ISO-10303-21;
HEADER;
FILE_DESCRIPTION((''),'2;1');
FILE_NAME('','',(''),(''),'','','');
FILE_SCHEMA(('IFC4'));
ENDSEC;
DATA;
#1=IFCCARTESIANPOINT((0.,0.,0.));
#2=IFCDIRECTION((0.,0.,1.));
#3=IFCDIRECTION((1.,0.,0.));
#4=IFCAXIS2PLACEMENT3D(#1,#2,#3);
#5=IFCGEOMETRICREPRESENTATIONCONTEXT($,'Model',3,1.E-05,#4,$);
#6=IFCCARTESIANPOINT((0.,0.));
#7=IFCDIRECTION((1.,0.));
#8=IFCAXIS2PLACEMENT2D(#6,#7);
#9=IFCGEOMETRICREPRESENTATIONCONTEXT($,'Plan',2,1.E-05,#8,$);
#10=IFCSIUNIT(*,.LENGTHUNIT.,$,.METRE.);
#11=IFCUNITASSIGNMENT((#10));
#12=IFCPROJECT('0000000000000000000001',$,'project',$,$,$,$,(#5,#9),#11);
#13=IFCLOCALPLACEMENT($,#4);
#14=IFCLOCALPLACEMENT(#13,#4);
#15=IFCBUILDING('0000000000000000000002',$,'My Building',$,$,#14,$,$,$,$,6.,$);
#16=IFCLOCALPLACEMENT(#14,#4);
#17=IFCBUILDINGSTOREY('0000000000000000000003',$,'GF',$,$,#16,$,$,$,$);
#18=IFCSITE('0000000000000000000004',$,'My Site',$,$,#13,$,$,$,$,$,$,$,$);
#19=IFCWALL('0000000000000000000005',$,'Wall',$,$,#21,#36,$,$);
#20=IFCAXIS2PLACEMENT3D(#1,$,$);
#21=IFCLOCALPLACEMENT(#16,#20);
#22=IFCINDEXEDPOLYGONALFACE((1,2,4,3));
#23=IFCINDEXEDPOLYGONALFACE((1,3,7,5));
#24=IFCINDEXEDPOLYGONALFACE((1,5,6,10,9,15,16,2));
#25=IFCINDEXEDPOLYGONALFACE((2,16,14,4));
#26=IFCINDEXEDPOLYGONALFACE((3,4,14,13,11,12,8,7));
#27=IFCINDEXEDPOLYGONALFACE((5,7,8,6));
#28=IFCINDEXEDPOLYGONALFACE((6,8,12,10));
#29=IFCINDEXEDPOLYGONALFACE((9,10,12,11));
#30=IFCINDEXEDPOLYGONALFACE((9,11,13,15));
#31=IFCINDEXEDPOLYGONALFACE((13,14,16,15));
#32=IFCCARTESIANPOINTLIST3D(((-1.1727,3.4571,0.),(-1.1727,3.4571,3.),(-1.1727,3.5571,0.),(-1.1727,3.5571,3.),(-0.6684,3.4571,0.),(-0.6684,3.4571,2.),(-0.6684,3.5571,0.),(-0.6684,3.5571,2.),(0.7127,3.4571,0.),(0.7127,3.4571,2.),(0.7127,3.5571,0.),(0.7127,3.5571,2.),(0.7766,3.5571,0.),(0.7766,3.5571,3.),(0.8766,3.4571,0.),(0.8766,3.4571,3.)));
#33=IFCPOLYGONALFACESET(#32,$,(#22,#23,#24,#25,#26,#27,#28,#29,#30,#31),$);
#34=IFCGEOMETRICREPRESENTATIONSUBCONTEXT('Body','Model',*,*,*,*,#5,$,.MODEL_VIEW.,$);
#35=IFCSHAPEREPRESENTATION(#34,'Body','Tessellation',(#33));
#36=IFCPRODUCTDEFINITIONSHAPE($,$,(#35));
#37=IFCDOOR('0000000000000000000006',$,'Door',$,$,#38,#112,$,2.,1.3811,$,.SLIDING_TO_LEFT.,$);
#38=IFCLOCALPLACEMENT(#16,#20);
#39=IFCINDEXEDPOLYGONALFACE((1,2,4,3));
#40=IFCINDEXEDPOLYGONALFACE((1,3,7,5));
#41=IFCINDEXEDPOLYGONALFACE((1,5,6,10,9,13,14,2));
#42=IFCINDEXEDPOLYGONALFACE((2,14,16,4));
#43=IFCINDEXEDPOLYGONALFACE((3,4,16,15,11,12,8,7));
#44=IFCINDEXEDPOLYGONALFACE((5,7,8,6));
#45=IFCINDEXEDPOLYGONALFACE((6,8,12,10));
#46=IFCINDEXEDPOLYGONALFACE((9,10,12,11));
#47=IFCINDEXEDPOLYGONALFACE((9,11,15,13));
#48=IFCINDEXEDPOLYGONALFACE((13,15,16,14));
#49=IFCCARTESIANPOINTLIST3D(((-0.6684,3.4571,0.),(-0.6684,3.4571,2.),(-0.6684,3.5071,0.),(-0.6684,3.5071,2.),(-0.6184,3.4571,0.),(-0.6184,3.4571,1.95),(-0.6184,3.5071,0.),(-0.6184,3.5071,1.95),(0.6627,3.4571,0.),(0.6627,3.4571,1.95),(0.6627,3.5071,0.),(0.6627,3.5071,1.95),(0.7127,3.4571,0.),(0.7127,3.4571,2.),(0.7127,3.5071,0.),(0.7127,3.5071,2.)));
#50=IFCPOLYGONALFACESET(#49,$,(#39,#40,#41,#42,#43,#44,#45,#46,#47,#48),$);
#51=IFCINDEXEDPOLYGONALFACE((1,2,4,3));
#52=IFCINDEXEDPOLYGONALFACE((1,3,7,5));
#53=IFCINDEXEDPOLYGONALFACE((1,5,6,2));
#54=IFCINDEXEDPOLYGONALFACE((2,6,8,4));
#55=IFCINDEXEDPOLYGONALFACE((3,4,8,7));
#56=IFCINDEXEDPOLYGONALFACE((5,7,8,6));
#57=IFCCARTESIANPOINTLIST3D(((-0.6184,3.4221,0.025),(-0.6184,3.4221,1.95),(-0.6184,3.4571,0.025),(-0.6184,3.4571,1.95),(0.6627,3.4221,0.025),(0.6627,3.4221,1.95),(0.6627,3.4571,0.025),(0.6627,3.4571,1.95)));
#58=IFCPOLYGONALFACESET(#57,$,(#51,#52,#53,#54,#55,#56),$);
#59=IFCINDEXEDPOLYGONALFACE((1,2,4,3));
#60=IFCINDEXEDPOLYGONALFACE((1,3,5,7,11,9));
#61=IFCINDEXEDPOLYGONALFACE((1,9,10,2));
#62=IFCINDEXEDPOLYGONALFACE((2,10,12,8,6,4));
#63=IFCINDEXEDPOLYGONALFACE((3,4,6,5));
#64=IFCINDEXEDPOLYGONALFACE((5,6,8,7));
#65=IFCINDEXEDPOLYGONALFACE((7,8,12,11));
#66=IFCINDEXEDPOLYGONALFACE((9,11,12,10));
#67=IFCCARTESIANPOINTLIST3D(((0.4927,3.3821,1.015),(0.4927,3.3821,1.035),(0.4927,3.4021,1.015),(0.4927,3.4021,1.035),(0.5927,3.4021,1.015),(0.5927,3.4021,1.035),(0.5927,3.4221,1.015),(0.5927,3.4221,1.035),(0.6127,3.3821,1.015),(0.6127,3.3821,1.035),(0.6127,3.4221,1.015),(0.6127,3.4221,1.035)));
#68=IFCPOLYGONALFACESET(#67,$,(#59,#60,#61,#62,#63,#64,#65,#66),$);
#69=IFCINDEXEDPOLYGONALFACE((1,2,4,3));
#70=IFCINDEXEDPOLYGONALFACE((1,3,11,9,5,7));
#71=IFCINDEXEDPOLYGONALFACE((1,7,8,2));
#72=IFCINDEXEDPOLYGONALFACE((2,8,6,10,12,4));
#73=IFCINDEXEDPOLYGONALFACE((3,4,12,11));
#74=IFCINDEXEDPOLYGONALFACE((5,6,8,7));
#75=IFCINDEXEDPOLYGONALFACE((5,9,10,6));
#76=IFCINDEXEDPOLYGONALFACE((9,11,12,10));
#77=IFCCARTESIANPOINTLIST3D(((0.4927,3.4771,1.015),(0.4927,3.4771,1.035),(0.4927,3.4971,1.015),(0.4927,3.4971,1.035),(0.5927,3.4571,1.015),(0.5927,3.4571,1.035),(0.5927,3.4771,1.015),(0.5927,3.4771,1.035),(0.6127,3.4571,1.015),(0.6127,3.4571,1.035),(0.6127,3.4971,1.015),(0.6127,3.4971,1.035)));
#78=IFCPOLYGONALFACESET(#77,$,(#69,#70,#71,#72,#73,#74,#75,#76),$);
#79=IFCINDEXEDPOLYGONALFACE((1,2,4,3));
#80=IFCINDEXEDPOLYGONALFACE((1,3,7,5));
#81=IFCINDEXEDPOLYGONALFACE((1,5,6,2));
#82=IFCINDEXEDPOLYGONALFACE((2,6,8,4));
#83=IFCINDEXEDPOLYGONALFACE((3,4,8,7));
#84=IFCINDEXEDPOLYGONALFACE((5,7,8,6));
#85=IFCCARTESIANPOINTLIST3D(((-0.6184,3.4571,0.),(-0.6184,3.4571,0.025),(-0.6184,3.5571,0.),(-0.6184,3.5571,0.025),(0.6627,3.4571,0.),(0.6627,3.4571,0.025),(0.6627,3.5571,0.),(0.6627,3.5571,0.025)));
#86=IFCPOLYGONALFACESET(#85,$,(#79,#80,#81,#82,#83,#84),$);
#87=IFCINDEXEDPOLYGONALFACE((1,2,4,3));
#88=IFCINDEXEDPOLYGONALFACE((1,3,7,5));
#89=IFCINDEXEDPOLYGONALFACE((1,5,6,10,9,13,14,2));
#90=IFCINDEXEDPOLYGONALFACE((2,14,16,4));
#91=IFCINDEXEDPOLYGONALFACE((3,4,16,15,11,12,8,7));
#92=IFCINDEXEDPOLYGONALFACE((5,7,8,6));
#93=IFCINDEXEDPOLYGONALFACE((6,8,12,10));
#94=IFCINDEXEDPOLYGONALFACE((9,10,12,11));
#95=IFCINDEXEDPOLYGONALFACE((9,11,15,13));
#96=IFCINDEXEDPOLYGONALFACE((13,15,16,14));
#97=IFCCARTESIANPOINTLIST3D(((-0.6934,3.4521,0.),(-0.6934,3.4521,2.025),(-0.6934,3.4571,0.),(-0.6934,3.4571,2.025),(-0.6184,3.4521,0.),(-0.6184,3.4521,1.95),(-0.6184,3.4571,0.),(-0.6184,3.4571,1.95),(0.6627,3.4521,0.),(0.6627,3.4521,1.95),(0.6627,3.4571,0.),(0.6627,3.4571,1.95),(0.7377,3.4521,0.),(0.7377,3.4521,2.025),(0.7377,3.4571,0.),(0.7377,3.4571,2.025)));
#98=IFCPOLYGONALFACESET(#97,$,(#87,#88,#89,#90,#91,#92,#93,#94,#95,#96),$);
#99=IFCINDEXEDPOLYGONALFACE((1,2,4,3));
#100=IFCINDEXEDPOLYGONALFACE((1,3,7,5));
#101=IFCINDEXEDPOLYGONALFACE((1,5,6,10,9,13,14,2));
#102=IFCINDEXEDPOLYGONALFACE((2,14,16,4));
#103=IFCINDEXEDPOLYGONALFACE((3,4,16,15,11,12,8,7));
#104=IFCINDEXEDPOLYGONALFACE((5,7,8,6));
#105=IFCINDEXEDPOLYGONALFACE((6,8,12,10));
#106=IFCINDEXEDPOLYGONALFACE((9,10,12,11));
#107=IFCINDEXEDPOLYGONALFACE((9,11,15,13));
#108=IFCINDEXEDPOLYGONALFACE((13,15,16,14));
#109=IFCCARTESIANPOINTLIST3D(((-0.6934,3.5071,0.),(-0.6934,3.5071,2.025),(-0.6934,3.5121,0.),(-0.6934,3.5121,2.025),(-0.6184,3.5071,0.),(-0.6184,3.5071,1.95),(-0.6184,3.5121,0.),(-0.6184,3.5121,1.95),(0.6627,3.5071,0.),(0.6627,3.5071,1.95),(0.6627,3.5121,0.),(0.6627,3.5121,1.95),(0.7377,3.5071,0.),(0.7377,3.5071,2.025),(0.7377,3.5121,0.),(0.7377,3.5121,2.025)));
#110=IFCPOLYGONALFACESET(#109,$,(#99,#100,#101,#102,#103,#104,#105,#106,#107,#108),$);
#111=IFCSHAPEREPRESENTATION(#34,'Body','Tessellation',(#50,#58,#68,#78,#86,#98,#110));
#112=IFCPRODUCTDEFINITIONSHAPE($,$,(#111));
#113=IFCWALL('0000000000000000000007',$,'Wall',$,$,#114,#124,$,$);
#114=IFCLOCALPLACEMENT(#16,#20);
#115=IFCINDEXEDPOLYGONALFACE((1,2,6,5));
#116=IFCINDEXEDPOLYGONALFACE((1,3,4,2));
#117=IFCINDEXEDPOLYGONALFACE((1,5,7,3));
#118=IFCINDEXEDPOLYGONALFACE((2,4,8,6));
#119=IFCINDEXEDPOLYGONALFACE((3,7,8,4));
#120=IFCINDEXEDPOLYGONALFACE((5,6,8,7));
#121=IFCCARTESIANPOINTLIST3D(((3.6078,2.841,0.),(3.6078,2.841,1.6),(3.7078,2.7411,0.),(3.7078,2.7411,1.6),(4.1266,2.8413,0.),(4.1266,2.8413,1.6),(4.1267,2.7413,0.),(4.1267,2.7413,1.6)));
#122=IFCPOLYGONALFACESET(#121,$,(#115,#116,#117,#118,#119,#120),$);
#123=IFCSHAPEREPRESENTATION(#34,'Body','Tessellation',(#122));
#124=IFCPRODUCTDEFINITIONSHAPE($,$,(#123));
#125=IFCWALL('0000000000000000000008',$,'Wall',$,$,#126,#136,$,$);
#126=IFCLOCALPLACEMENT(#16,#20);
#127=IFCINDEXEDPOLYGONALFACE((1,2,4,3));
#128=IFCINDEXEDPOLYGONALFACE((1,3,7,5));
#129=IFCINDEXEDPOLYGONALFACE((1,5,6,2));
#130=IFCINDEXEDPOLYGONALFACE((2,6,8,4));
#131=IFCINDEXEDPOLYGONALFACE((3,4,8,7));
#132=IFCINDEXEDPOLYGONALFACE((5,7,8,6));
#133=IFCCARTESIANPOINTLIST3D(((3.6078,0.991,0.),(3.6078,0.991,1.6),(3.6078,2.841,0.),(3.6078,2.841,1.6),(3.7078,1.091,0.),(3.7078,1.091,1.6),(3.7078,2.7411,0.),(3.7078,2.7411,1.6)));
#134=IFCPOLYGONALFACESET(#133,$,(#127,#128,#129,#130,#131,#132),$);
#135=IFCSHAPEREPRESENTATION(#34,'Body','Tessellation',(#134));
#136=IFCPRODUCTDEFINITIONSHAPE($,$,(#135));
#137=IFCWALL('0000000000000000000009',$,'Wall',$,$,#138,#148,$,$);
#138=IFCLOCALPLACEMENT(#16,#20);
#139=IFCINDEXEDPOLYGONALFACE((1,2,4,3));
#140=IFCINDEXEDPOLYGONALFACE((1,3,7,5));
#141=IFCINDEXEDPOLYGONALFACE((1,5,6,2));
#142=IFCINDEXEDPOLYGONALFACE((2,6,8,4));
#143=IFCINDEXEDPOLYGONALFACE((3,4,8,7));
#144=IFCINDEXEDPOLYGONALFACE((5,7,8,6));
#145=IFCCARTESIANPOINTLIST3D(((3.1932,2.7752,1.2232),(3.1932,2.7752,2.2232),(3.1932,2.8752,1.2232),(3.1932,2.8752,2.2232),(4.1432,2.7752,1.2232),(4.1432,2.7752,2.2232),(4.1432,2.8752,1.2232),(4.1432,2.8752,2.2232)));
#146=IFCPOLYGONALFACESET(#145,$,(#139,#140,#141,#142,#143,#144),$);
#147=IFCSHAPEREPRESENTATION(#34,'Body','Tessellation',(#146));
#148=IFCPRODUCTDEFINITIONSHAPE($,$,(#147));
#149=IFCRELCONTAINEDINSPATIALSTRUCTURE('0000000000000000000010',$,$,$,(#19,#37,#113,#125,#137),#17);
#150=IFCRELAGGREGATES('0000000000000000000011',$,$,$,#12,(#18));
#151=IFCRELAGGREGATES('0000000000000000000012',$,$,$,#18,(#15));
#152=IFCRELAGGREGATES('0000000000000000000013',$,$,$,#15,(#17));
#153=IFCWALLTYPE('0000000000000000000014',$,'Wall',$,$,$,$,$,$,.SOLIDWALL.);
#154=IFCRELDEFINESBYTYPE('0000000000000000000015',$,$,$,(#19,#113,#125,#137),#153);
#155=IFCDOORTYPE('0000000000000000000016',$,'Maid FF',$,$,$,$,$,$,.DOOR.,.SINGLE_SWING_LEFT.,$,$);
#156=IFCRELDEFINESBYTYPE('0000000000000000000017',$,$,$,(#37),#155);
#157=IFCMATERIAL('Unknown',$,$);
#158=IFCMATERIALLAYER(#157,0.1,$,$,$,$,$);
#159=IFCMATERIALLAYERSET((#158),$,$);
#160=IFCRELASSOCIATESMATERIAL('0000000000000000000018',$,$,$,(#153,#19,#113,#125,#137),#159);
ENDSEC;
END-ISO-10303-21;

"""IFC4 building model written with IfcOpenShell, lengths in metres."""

from ifc_helpers import new_model, entity, si_unit, frame, origin_with_axes, origin_2d_with_axis, place, context, subcontext, project, spatial, line, indexed_curve, outline, extrude, shape, source, transform, mapped, material, layer, layer_set, layer_usage, type_object, type_shapes, element, fill, save


model = new_model("IFC4")

# Units and contexts
model_context = context("Model", 3, precision=1e-05, world=origin_with_axes())
plan_context = context("Plan", 2, precision=1e-05, world=origin_2d_with_axis())
body_context_1 = subcontext(model_context, "Body", "Model", "MODEL_VIEW")
body_context_2 = subcontext(plan_context, "Body", "Plan", "PLAN_VIEW")
ifc_project = project(units=[si_unit("LENGTHUNIT", "METRE")], contexts=[model_context, plan_context])

# Site, building, storey
site_placement = place(None, origin_with_axes())
site = spatial("IfcSite", under=ifc_project, at=site_placement, Name="My Site")
building_placement = place(site_placement, origin_with_axes())
building = spatial("IfcBuilding", under=site, at=building_placement, Name="My Building", ElevationOfTerrain=6.0)
storey_placement = place(building_placement, origin_with_axes())
storey = spatial("IfcBuildingStorey", under=building, at=storey_placement, Name="GF")

# Shared definitions
ifc_material_1 = material(Name="Unknown")
ifc_layer = layer(ifc_material_1, 0.1)
ifc_layer_set = layer_set([ifc_layer])
wall_type = type_object("IfcWallType", Name="Wall", PredefinedType="SOLIDWALL", material=ifc_layer_set)

# Wall, opening, door
ifc_layer_usage_1 = layer_usage(ifc_layer_set, "AXIS2", "POSITIVE", 0.0)
wall_1_placement = place(storey_placement, frame((0.7766, 3.5571, 0.0), z_axis=(0.0, 0.0, 1.0), x_axis=(-1.0, 0.0, 0.0)))
wall_1 = element("IfcWall", 1, at=wall_1_placement, inside=storey, type_object=wall_type, material=ifc_layer_usage_1, Name="Wall", context=body_context_1, shape_type="SweptSolid", body=[
    extrude(outline(indexed_curve([(0.0, 0.0), (-0.1, 0.1), (1.9493, 0.1), (1.9493, 0.0)], segments=[line(1, 2, 3, 4, 1)])), origin_with_axes(), (0.0, 0.0, 1.0), 3.0),
])
shared_shape_1 = source(origin_with_axes(), body_context_1, "Body", "SweptSolid", [
    extrude(outline(indexed_curve([(0.0, 0.0), (1.3811, 0.0), (1.3811, 2.0), (0.0, 2.0)], segments=[line(1, 2, 3, 4, 1)])), frame((0.0, -0.6, 0.0), z_axis=(0.0, -1.0, 0.0), x_axis=(1.0, 0.0, 0.0)), (0.0, 0.0, -1.0), 1.2),
])
opening_1_placement = place(wall_1_placement, frame((1.445, 0.1, 0.0), z_axis=(0.0, 0.0, 1.0), x_axis=(-1.0, 0.000001, 0.0)))
opening_1 = element("IfcOpeningElement", 2, at=opening_1_placement, cuts=wall_1, PredefinedType="OPENING", context=body_context_1, shape_type="MappedRepresentation", body=[
    mapped(shared_shape_1, transform((0.0, 0.0, 0.0), x_axis=(1.0, 0.0, 0.0), y_axis=(0.0, 1.0, 0.0), z_axis=(0.0, 0.0, 1.0), scale=1.0)),
])
door_type_1 = type_object("IfcDoorType", Name="Maid FF", OperationType="SINGLE_SWING_LEFT", PredefinedType="DOOR")
shared_shape_2 = source(origin_with_axes(), body_context_1, "Body", "SweptSolid", [
    extrude(outline(indexed_curve([(0.0, 0.0), (0.0, 2.0), (1.3811, 2.0), (1.3811, 0.0), (1.3311, 0.0), (1.3311, 1.95), (0.05, 1.95), (0.05, 0.0)], segments=[line(1, 2, 3, 4, 5, 6, 7, 8, 1)])), frame((0.0, 0.0, 0.0), z_axis=(0.0, -1.0, 0.0), x_axis=(1.0, 0.0, 0.0)), (0.0, 0.0, -1.0), 0.05),
    extrude(outline(indexed_curve([(0.0, 0.0), (1.2811, 0.0), (1.2811, 0.035), (0.0, 0.035)], segments=[line(1, 2, 3, 4, 1)])), frame((0.05, -0.035, 0.025), z_axis=(0.0, 0.0, 1.0), x_axis=(1.0, 0.0, 0.0)), (0.0, 0.0, 1.0), 1.925),
    extrude(outline(indexed_curve([(0.0, 0.0), (0.0, -0.04), (-0.12, -0.04), (-0.12, -0.02), (-0.02, -0.02), (-0.02, 0.0)], segments=[line(1, 2, 3, 4, 5, 6, 1)])), frame((1.2811, -0.035, 1.015), z_axis=(0.0, 0.0, 1.0), x_axis=(1.0, 0.0, 0.0)), (0.0, 0.0, 1.0), 0.02),
    extrude(outline(indexed_curve([(0.0, 0.0), (0.0, 0.04), (-0.12, 0.04), (-0.12, 0.02), (-0.02, 0.02), (-0.02, 0.0)], segments=[line(1, 2, 3, 4, 5, 6, 1)])), frame((1.2811, 0.0, 1.015), z_axis=(0.0, 0.0, 1.0), x_axis=(1.0, 0.0, 0.0)), (0.0, 0.0, 1.0), 0.02),
    extrude(outline(indexed_curve([(0.0, 0.0), (1.2811, 0.0), (1.2811, 0.1), (0.0, 0.1)], segments=[line(1, 2, 3, 4, 1)])), frame((0.05, 0.0, 0.0), z_axis=(0.0, 0.0, 1.0), x_axis=(1.0, 0.0, 0.0)), (0.0, 0.0, 1.0), 0.025),
    extrude(outline(indexed_curve([(0.0, 0.0), (0.0, 2.025), (1.4311, 2.025), (1.4311, 0.0), (1.3561, 0.0), (1.3561, 1.95), (0.075, 1.95), (0.075, 0.0)], segments=[line(1, 2, 3, 4, 5, 6, 7, 8, 1)])), frame((-0.025, -0.005, 0.0), z_axis=(0.0, -1.0, 0.0), x_axis=(1.0, 0.0, 0.0)), (0.0, 0.0, -1.0), 0.005),
    extrude(outline(indexed_curve([(0.0, 0.0), (0.0, 2.025), (1.4311, 2.025), (1.4311, 0.0), (1.3561, 0.0), (1.3561, 1.95), (0.075, 1.95), (0.075, 0.0)], segments=[line(1, 2, 3, 4, 5, 6, 7, 8, 1)])), frame((-0.025, 0.05, 0.0), z_axis=(0.0, -1.0, 0.0), x_axis=(1.0, 0.0, 0.0)), (0.0, 0.0, -1.0), 0.005),
])
shared_shape_3 = source(origin_with_axes(), body_context_2, "Body", "Curve2D", [
    entity("IfcIndexedPolyCurve", entity("IfcCartesianPointList2D", [[0.0, 0.0], [0.05, 0.0], [0.05, 0.05], [0.0, 0.05]]), [entity("IfcLineIndex", [1, 2, 3, 4, 1])]),
    entity("IfcIndexedPolyCurve", entity("IfcCartesianPointList2D", [[1.3811, 0.0], [1.3311, 0.0], [1.3311, 0.05], [1.3811, 0.05]]), [entity("IfcLineIndex", [1, 2, 3, 4, 1])]),
    entity("IfcIndexedPolyCurve", entity("IfcCartesianPointList2D", [[-0.5906, -0.035], [0.6906, -0.035], [0.6906, 0.0], [-0.5906, 0.0]]), [entity("IfcLineIndex", [1, 2, 3, 4, 1])]),
])
type_shapes(door_type_1, [shared_shape_2, shared_shape_3])
door_1_placement = place(opening_1_placement, frame((0.0, 0.0, 0.0), z_axis=(0.0, 0.0, 1.0), x_axis=(1.0, 0.0, 0.0)))
door_1 = element("IfcDoor", 3, at=door_1_placement, inside=storey, type_object=door_type_1, Name="Door", OperationType="SLIDING_TO_LEFT", OverallHeight=2.0, OverallWidth=1.3811, shapes=[
    shape(body_context_1, "Body", "MappedRepresentation", [mapped(shared_shape_2, transform((0.0, 0.0, 0.0), x_axis=(1.0, 0.0, 0.0), y_axis=(0.0, 1.0, 0.0), z_axis=(0.0, 0.0, 1.0), scale=1.0))]),
    shape(body_context_2, "Body", "MappedRepresentation", [mapped(shared_shape_3, transform((0.0, 0.0, 0.0), x_axis=(1.0, 0.0, 0.0), y_axis=(0.0, 1.0, 0.0), z_axis=(0.0, 0.0, 1.0), scale=1.0))]),
])
fill(opening_1, door_1)

# Walls
ifc_layer_usage_2 = layer_usage(ifc_layer_set, "AXIS2", "POSITIVE", 0.0)
wall_2_placement = place(storey_placement, frame((4.1266, 2.8413, 0.0), z_axis=(0.0, 0.0, 1.0), x_axis=(-1.0, -0.000506, 0.0)))
element("IfcWall", 4, at=wall_2_placement, inside=storey, type_object=wall_type, material=ifc_layer_usage_2, Name="Wall", context=body_context_1, shape_type="SweptSolid", body=[
    extrude(outline(indexed_curve([(0.0, 0.0), (0.0, 0.1), (0.4189, 0.1), (0.5188, 0.0)], segments=[line(1, 2, 3, 4, 1)])), origin_with_axes(), (0.0, 0.0, 1.0), 1.6),
])
ifc_layer_usage_3 = layer_usage(ifc_layer_set, "AXIS2", "POSITIVE", 0.0)
wall_3_placement = place(storey_placement, frame((3.6078, 2.841, 0.0), z_axis=(0.0, 0.0, 1.0), x_axis=(0.0, -1.0, 0.0)))
element("IfcWall", 5, at=wall_3_placement, inside=storey, type_object=wall_type, material=ifc_layer_usage_3, Name="Wall", context=body_context_1, shape_type="SweptSolid", body=[
    extrude(outline(indexed_curve([(0.0, 0.0), (0.0999, 0.1), (1.75, 0.1), (1.85, 0.0)], segments=[line(1, 2, 3, 4, 1)])), origin_with_axes(), (0.0, 0.0, 1.0), 1.6),
])
ifc_layer_usage_4 = layer_usage(ifc_layer_set, "AXIS2", "POSITIVE", 0.0)
wall_4_placement = place(storey_placement, frame((3.1932, 2.7752, 1.2232), z_axis=(0.0, 0.0, 1.0), x_axis=(1.0, 0.0, 0.0)))
element("IfcWall", 6, at=wall_4_placement, inside=storey, type_object=wall_type, material=ifc_layer_usage_4, Name="Wall", context=body_context_1, shape_type="SweptSolid", body=[
    extrude(outline(indexed_curve([(0.0, 0.0), (0.0, 0.1), (0.95, 0.1), (0.95, 0.0)], segments=[line(1, 2, 3, 4, 1)])), origin_with_axes(), (0.0, 0.0, 1.0), 1.0),
])

save(model, "model.ifc")
